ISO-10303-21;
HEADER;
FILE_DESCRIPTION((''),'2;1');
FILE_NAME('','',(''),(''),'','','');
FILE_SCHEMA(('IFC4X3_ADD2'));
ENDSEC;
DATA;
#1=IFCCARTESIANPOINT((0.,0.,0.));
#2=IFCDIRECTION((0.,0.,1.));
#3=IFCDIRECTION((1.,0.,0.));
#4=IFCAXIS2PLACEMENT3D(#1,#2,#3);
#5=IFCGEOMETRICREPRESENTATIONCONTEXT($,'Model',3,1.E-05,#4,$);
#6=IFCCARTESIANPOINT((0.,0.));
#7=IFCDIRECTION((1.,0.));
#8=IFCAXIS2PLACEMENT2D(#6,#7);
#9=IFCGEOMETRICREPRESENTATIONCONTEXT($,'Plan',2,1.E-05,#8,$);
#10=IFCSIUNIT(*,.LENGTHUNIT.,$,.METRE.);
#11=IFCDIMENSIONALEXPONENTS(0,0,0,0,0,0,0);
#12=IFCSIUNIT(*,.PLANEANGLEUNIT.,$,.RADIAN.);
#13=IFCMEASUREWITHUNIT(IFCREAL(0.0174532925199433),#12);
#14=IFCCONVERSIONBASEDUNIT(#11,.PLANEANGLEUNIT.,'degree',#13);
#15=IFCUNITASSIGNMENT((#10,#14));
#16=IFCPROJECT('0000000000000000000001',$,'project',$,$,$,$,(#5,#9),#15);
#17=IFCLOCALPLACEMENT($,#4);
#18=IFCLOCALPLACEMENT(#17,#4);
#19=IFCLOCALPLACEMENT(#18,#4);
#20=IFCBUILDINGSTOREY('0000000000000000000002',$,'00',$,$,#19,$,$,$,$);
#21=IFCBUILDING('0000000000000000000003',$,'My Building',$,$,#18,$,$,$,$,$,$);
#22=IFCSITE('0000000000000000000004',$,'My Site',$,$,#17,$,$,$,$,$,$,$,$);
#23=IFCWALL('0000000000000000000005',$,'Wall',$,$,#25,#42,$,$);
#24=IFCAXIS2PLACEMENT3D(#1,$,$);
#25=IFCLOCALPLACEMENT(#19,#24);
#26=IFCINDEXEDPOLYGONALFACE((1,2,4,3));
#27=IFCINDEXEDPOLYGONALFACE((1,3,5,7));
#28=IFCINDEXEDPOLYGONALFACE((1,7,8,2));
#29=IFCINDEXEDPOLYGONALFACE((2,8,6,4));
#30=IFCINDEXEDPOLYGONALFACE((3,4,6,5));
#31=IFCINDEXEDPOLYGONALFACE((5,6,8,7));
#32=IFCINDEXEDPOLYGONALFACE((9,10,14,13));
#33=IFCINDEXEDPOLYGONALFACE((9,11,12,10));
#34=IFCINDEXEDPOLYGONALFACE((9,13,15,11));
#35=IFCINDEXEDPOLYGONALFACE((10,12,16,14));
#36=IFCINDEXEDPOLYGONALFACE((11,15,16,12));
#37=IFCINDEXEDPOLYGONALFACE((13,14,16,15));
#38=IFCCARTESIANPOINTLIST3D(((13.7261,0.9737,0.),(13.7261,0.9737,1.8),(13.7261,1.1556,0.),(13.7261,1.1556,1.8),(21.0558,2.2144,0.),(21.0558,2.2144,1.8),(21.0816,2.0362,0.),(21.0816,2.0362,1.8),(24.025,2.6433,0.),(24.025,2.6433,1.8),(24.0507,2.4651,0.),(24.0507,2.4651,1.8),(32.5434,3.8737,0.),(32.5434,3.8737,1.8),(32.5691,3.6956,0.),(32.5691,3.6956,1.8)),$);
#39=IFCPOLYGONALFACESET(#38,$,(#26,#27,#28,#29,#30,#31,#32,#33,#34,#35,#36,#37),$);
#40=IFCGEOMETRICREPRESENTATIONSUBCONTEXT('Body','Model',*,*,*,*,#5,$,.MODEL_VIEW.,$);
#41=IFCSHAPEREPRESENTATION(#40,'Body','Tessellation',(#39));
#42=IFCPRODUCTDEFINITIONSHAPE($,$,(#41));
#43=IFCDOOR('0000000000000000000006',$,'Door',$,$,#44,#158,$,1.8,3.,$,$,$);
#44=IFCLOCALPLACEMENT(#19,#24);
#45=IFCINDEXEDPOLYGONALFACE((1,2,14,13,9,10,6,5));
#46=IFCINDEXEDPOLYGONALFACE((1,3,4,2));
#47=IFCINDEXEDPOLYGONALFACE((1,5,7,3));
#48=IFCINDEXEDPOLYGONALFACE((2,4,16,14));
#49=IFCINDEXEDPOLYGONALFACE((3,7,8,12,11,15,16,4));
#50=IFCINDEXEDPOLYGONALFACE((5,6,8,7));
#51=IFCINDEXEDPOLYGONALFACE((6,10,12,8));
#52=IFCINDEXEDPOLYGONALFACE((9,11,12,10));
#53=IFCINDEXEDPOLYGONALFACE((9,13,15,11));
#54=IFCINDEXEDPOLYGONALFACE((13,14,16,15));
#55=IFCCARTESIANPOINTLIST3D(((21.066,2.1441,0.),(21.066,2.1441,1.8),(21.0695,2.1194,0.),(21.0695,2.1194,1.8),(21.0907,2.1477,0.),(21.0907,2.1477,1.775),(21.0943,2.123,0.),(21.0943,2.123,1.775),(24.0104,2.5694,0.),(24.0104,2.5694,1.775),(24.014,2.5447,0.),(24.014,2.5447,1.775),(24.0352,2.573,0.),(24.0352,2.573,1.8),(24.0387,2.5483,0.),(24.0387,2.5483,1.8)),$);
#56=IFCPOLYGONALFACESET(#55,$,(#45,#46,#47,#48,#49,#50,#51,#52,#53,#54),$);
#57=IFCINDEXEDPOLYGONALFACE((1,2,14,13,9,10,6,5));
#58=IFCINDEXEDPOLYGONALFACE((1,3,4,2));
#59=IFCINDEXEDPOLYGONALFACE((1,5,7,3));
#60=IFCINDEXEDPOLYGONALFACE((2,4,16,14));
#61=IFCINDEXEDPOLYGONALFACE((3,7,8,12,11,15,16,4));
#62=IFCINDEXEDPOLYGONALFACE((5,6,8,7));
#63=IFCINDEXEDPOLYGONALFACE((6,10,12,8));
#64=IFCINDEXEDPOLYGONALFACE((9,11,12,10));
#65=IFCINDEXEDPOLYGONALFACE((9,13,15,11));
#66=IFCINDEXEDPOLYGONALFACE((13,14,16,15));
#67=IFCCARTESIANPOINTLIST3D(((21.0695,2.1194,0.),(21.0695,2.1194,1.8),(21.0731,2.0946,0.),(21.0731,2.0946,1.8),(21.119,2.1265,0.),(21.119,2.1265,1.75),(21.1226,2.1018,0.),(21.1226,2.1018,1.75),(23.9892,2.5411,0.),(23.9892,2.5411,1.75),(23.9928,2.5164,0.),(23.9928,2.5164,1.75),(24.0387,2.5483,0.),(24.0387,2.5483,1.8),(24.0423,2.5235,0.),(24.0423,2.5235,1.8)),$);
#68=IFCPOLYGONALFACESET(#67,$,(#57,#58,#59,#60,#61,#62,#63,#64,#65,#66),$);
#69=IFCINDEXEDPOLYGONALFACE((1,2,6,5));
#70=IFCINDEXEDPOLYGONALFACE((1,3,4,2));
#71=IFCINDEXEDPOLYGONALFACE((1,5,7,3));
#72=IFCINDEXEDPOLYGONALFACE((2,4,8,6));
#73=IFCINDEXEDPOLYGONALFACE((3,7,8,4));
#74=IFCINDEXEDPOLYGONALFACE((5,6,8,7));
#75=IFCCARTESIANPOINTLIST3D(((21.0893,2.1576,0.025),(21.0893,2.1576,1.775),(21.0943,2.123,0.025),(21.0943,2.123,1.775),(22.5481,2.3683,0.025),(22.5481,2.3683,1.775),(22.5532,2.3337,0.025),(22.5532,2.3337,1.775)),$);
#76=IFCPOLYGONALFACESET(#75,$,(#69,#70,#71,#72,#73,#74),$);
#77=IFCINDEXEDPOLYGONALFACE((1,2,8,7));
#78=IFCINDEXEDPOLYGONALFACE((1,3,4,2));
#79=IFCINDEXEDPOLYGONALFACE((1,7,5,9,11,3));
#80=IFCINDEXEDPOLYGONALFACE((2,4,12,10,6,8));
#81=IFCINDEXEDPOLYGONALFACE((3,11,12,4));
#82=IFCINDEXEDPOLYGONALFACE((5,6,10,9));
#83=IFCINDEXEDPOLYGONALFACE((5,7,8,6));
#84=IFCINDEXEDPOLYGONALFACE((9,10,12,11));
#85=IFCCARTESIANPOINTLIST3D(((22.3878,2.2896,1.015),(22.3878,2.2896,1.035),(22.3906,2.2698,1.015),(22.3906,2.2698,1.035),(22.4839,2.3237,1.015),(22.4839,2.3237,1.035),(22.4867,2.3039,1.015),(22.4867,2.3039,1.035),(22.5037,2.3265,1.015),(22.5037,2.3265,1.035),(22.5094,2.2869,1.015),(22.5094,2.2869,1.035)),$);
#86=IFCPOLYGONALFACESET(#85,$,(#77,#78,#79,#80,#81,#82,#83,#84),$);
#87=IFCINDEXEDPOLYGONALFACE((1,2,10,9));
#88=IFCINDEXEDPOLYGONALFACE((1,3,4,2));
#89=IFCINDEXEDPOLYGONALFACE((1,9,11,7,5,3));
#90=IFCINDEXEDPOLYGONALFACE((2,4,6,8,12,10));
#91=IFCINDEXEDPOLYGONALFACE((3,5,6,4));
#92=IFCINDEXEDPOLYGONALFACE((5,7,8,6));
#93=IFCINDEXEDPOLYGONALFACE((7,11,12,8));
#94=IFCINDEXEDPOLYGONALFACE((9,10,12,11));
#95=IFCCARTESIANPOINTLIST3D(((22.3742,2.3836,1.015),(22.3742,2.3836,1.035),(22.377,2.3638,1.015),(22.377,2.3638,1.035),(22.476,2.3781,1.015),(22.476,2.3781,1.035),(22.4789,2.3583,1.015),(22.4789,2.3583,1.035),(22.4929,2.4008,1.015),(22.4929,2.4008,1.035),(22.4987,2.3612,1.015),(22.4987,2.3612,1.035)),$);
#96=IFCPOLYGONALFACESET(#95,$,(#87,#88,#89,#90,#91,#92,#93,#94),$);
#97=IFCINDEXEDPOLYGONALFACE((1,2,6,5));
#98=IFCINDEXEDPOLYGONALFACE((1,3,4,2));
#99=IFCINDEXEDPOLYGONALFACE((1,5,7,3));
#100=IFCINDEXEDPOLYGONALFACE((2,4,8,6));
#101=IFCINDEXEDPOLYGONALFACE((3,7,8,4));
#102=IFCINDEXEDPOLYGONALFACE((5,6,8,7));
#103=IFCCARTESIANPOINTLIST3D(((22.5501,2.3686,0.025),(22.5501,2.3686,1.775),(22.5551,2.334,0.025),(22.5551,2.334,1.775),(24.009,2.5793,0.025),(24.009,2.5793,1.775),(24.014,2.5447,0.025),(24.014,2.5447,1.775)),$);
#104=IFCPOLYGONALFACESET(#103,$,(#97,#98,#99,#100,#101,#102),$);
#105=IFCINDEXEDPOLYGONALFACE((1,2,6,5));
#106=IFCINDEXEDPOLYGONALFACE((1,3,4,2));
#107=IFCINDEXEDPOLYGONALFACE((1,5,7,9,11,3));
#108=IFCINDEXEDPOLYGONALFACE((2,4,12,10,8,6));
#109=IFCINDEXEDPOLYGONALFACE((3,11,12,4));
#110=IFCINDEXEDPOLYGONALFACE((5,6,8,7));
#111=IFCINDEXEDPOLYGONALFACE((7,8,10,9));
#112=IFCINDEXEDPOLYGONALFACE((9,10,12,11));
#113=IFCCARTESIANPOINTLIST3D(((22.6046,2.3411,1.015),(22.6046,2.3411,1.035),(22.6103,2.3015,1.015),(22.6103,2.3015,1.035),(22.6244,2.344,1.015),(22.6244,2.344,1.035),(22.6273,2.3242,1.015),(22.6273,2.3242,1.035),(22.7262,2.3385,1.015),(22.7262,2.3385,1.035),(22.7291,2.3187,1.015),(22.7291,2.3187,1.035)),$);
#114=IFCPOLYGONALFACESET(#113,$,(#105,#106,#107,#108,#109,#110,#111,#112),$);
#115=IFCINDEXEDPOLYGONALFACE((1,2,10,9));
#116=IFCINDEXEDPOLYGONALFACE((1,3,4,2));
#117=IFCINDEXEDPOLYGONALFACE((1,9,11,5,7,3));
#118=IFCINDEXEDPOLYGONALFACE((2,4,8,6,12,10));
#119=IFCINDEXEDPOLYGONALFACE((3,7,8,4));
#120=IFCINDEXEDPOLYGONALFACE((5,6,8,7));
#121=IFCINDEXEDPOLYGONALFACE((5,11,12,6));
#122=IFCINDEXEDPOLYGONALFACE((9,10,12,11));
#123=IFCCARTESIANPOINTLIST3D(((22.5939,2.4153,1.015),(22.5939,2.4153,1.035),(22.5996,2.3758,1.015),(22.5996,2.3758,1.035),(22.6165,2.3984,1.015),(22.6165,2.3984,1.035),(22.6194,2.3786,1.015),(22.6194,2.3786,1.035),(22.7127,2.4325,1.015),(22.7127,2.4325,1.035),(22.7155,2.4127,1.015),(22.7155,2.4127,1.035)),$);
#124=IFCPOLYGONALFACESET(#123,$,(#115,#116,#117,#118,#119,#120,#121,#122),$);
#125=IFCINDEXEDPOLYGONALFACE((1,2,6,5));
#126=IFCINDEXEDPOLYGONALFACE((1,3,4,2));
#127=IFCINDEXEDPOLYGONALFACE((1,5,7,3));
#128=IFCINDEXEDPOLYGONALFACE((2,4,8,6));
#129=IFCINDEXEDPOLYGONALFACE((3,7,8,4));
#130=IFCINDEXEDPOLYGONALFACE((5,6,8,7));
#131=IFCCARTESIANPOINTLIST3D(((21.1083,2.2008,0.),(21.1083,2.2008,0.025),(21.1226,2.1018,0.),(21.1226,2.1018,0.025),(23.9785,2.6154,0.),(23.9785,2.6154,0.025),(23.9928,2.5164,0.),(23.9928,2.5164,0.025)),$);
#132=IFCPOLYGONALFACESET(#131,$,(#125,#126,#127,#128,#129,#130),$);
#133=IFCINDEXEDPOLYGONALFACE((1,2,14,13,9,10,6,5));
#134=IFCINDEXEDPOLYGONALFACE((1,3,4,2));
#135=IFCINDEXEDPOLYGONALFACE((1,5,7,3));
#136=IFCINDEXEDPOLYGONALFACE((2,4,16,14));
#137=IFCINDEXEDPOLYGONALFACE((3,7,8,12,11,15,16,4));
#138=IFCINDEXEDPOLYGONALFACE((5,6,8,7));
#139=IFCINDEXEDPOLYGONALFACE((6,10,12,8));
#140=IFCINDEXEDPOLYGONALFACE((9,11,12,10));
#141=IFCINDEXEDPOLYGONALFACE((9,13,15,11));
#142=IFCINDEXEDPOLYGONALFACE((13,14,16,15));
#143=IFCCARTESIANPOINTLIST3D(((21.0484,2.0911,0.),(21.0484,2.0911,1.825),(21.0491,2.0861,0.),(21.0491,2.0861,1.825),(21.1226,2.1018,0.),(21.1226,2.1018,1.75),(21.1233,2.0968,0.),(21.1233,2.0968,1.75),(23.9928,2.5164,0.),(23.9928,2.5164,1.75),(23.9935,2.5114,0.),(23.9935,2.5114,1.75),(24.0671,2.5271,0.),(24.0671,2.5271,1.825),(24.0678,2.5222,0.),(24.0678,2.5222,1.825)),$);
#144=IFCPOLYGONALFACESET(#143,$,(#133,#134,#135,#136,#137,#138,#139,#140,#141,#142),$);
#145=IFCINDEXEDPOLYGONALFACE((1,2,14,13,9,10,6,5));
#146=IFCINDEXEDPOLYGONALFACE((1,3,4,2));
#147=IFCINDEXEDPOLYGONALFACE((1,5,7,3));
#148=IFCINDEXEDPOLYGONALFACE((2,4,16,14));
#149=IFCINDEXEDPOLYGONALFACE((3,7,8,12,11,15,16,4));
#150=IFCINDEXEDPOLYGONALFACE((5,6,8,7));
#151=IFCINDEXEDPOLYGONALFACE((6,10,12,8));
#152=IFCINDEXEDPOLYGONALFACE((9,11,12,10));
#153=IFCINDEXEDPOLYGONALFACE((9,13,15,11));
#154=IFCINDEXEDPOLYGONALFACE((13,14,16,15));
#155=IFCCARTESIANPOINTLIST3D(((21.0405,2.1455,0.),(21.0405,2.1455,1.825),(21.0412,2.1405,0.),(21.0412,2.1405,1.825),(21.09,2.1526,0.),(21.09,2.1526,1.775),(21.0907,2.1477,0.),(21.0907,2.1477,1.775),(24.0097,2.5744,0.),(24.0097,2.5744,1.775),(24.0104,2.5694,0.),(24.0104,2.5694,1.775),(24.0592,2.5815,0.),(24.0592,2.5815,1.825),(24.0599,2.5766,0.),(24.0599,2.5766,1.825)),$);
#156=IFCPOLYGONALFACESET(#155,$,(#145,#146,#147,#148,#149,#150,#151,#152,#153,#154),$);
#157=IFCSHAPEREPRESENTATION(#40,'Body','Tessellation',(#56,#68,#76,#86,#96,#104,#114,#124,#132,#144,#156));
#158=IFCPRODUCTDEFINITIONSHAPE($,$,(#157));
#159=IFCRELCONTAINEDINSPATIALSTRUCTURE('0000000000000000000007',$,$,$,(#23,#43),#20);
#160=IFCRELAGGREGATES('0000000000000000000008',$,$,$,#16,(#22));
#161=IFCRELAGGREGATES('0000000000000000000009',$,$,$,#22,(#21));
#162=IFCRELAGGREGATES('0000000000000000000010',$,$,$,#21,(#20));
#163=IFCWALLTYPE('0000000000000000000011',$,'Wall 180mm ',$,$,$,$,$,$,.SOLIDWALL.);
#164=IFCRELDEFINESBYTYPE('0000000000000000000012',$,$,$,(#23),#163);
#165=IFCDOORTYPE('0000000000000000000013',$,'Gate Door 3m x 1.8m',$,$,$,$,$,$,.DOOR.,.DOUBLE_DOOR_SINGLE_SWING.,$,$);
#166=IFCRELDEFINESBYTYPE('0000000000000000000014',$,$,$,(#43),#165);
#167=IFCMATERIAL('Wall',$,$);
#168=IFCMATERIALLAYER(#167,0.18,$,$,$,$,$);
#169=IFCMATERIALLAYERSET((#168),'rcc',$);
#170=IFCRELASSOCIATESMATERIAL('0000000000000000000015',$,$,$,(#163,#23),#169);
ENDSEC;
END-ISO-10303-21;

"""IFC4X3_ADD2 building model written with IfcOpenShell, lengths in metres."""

from ifc_helpers import new_model, entity, si_unit, converted_unit, frame, origin_with_axes, origin_2d_with_axis, place, context, subcontext, project, spatial, line, indexed_curve, outline, extrude, clip, halfspace, shape, source, transform, mapped, material, layer, layer_set, layer_usage, type_object, type_shapes, element, fill, save


model = new_model("IFC4X3_ADD2")

# Units and contexts
model_context = context("Model", 3, precision=1e-05, world=origin_with_axes())
plan_context = context("Plan", 2, precision=1e-05, world=origin_2d_with_axis())
body_context_1 = subcontext(model_context, "Body", "Model", "MODEL_VIEW")
body_context_2 = subcontext(plan_context, "Body", "Plan", "PLAN_VIEW")
ifc_project = project(units=[si_unit("LENGTHUNIT", "METRE"), converted_unit("PLANEANGLEUNIT", "degree", entity("IfcReal", 0.0174532925199433), si_unit("PLANEANGLEUNIT", "RADIAN"), dimensions=[0, 0, 0, 0, 0, 0, 0])], contexts=[model_context, plan_context])

# Site, building, storey
site_placement = place(None, origin_with_axes())
site = spatial("IfcSite", under=ifc_project, at=site_placement, Name="My Site")
building_placement = place(site_placement, origin_with_axes())
building = spatial("IfcBuilding", under=site, at=building_placement, Name="My Building")
storey_placement = place(building_placement, origin_with_axes())
storey = spatial("IfcBuildingStorey", under=building, at=storey_placement, Name="00")

# Shared definitions
ifc_material_1 = material(Name="Wall")

# Shared definitions
ifc_layer_1 = layer(ifc_material_1, 0.18)
ifc_layer_set_1 = layer_set([ifc_layer_1], Name="rcc")
wall_type_1 = type_object("IfcWallType", Name="Wall 180mm ", PredefinedType="SOLIDWALL", material=ifc_layer_set_1)

# Wall, opening, door
ifc_layer_usage_1 = layer_usage(ifc_layer_set_1, "AXIS2", "POSITIVE", 0.0)
wall_1_placement = place(storey_placement, frame((13.4961, 0.9405, 0.0), z_axis=(0.0, 0.0, 1.0), x_axis=(0.989728, 0.142965, 0.0)))
wall_1 = element("IfcWall", 1, at=wall_1_placement, inside=storey, type_object=wall_type_1, material=ifc_layer_usage_1, Name="Wall", context=body_context_1, shape_type="Clipping", body=[
    clip(extrude(outline(indexed_curve([(0.0, 0.0), (0.0, 0.18), (19.271, 0.18), (19.271, 0.0), (0.0, 0.0)], self_intersect=False)), origin_with_axes(), (0.0, 0.0, 1.0), 1.8), halfspace(frame((0.2324, 0.0, 0.0), z_axis=(-0.324, 0.046802, 0.0), x_axis=(0.142965, 0.989728, 0.0)), False)),
])
shared_shape_1 = source(origin_with_axes(), body_context_1, "Body", "SweptSolid", [
    extrude(outline(indexed_curve([(0.0, 0.0), (3.0, 0.0), (3.0, 1.8), (0.0, 1.8)], segments=[line(1, 2, 3, 4, 1)])), frame((0.0, -0.6, 0.0), z_axis=(0.0, -1.0, 0.0), x_axis=(1.0, 0.0, 0.0)), (0.0, 0.0, -1.0), 1.2),
])
opening_1_placement = place(wall_1_placement, frame((7.6642, 0.059, 0.0), z_axis=(0.0, 0.0, 1.0), x_axis=(1.0, 0.0, 0.0)))
opening_1 = element("IfcOpeningElement", 2, at=opening_1_placement, cuts=wall_1, PredefinedType="OPENING", context=body_context_1, shape_type="MappedRepresentation", body=[
    mapped(shared_shape_1, transform((0.0, 0.0, 0.0), x_axis=(1.0, 0.0, 0.0), y_axis=(0.0, 1.0, 0.0), z_axis=(0.0, 0.0, 1.0), scale=1.0)),
])
door_type_1 = type_object("IfcDoorType", Name="Gate Door 3m x 1.8m", OperationType="DOUBLE_DOOR_SINGLE_SWING", PredefinedType="DOOR")
shared_shape_2 = source(origin_with_axes(), body_context_1, "Body", "SweptSolid", [
    extrude(outline(indexed_curve([(0.0, 0.0), (0.0, 1.8), (3.0, 1.8), (3.0, 0.0), (2.975, 0.0), (2.975, 1.775), (0.025, 1.775), (0.025, 0.0)], segments=[line(1, 2, 3, 4, 5, 6, 7, 8, 1)])), frame((0.0, 0.025, 0.0), z_axis=(0.0, -1.0, 0.0), x_axis=(1.0, 0.0, 0.0)), (0.0, 0.0, -1.0), 0.025),
    extrude(outline(indexed_curve([(0.0, 0.0), (0.0, 1.8), (3.0, 1.8), (3.0, 0.0), (2.95, 0.0), (2.95, 1.75), (0.05, 1.75), (0.05, 0.0)], segments=[line(1, 2, 3, 4, 5, 6, 7, 8, 1)])), frame((0.0, 0.0, 0.0), z_axis=(0.0, -1.0, 0.0), x_axis=(1.0, 0.0, 0.0)), (0.0, 0.0, -1.0), 0.025),
    extrude(outline(indexed_curve([(0.0, 0.0), (1.474, 0.0), (1.474, 0.035), (0.0, 0.035)], segments=[line(1, 2, 3, 4, 1)])), frame((0.025, 0.025, 0.025), z_axis=(0.0, 0.0, 1.0), x_axis=(1.0, 0.0, 0.0)), (0.0, 0.0, 1.0), 1.75),
    extrude(outline(indexed_curve([(0.0, 0.0), (0.0, -0.04), (-0.12, -0.04), (-0.12, -0.02), (-0.02, -0.02), (-0.02, 0.0)], segments=[line(1, 2, 3, 4, 5, 6, 1)])), frame((1.449, 0.025, 1.015), z_axis=(0.0, 0.0, 1.0), x_axis=(1.0, 0.0, 0.0)), (0.0, 0.0, 1.0), 0.02),
    extrude(outline(indexed_curve([(0.0, 0.0), (0.0, 0.04), (-0.12, 0.04), (-0.12, 0.02), (-0.02, 0.02), (-0.02, 0.0)], segments=[line(1, 2, 3, 4, 5, 6, 1)])), frame((1.449, 0.06, 1.015), z_axis=(0.0, 0.0, 1.0), x_axis=(1.0, 0.0, 0.0)), (0.0, 0.0, 1.0), 0.02),
    extrude(outline(indexed_curve([(0.0, 0.0), (-1.474, 0.0), (-1.474, 0.035), (0.0, 0.035)], segments=[line(1, 2, 3, 4, 1)])), frame((2.975, 0.025, 0.025), z_axis=(0.0, 0.0, 1.0), x_axis=(1.0, 0.0, 0.0)), (0.0, 0.0, 1.0), 1.75),
    extrude(outline(indexed_curve([(0.0, 0.0), (0.0, -0.04), (0.12, -0.04), (0.12, -0.02), (0.02, -0.02), (0.02, 0.0)], segments=[line(1, 2, 3, 4, 5, 6, 1)])), frame((1.551, 0.025, 1.015), z_axis=(0.0, 0.0, 1.0), x_axis=(1.0, 0.0, 0.0)), (0.0, 0.0, 1.0), 0.02),
    extrude(outline(indexed_curve([(0.0, 0.0), (0.0, 0.04), (0.12, 0.04), (0.12, 0.02), (0.02, 0.02), (0.02, 0.0)], segments=[line(1, 2, 3, 4, 5, 6, 1)])), frame((1.551, 0.06, 1.015), z_axis=(0.0, 0.0, 1.0), x_axis=(1.0, 0.0, 0.0)), (0.0, 0.0, 1.0), 0.02),
    extrude(outline(indexed_curve([(0.0, 0.0), (2.9, 0.0), (2.9, 0.1), (0.0, 0.1)], segments=[line(1, 2, 3, 4, 1)])), frame((0.05, 0.0, 0.0), z_axis=(0.0, 0.0, 1.0), x_axis=(1.0, 0.0, 0.0)), (0.0, 0.0, 1.0), 0.025),
    extrude(outline(indexed_curve([(0.0, 0.0), (0.0, 1.825), (3.05, 1.825), (3.05, 0.0), (2.975, 0.0), (2.975, 1.75), (0.075, 1.75), (0.075, 0.0)], segments=[line(1, 2, 3, 4, 5, 6, 7, 8, 1)])), frame((-0.025, -0.005, 0.0), z_axis=(0.0, -1.0, 0.0), x_axis=(1.0, 0.0, 0.0)), (0.0, 0.0, -1.0), 0.005),
    extrude(outline(indexed_curve([(0.0, 0.0), (0.0, 1.825), (3.05, 1.825), (3.05, 0.0), (3.0, 0.0), (3.0, 1.775), (0.05, 1.775), (0.05, 0.0)], segments=[line(1, 2, 3, 4, 5, 6, 7, 8, 1)])), frame((-0.025, 0.05, 0.0), z_axis=(0.0, -1.0, 0.0), x_axis=(1.0, 0.0, 0.0)), (0.0, 0.0, -1.0), 0.005),
])
shared_shape_3 = source(origin_with_axes(), body_context_2, "Body", "Curve2D", [
    entity("IfcIndexedPolyCurve", entity("IfcCartesianPointList2D", [[0.0, 0.0], [0.0, 0.05], [0.025, 0.05], [0.025, 0.025], [0.05, 0.025], [0.05, 0.0]]), [entity("IfcLineIndex", [1, 2, 3, 4, 5, 6, 1])]),
    entity("IfcIndexedPolyCurve", entity("IfcCartesianPointList2D", [[3.0, 0.0], [3.0, 0.05], [2.975, 0.05], [2.975, 0.025], [2.95, 0.025], [2.95, 0.0]]), [entity("IfcLineIndex", [1, 2, 3, 4, 5, 6, 1])]),
    entity("IfcTrimmedCurve", entity("IfcEllipse", entity("IfcAxis2Placement2D", entity("IfcCartesianPoint", [0.06, 0.05]), entity("IfcDirection", [1.0, 0.0])), 1.44, 1.475), [entity("IfcCartesianPoint", [1.5, 0.05])], [entity("IfcCartesianPoint", [0.06, 1.525])], True, "CARTESIAN"),
    entity("IfcIndexedPolyCurve", entity("IfcCartesianPointList2D", [[0.025, 0.05], [0.06, 0.05], [0.06, 1.525], [0.025, 1.525]]), [entity("IfcLineIndex", [1, 2, 3, 4, 1])]),
    entity("IfcTrimmedCurve", entity("IfcEllipse", entity("IfcAxis2Placement2D", entity("IfcCartesianPoint", [2.94, 0.05]), entity("IfcDirection", [1.0, 0.0])), 1.44, 1.475), [entity("IfcCartesianPoint", [2.94, 1.525])], [entity("IfcCartesianPoint", [1.5, 0.05])], True, "CARTESIAN"),
    entity("IfcIndexedPolyCurve", entity("IfcCartesianPointList2D", [[2.975, 0.05], [2.94, 0.05], [2.94, 1.525], [2.975, 1.525]]), [entity("IfcLineIndex", [1, 2, 3, 4, 1])]),
])
type_shapes(door_type_1, [shared_shape_2, shared_shape_3])
door_1_placement = place(opening_1_placement, frame((0.0, 0.0, 0.0), z_axis=(0.0, 0.0, 1.0), x_axis=(1.0, 0.0, 0.0)))
door_1 = element("IfcDoor", 3, at=door_1_placement, inside=storey, type_object=door_type_1, Name="Door", OverallHeight=1.8, OverallWidth=3.0, shapes=[
    shape(body_context_1, "Body", "MappedRepresentation", [mapped(shared_shape_2, transform((0.0, 0.0, 0.0), x_axis=(1.0, 0.0, 0.0), y_axis=(0.0, 1.0, 0.0), z_axis=(0.0, 0.0, 1.0), scale=1.0))]),
    shape(body_context_2, "Body", "MappedRepresentation", [mapped(shared_shape_3, transform((0.0, 0.0, 0.0), x_axis=(1.0, 0.0, 0.0), y_axis=(0.0, 1.0, 0.0), z_axis=(0.0, 0.0, 1.0), scale=1.0))]),
])
fill(opening_1, door_1)

save(model, "model.ifc")
